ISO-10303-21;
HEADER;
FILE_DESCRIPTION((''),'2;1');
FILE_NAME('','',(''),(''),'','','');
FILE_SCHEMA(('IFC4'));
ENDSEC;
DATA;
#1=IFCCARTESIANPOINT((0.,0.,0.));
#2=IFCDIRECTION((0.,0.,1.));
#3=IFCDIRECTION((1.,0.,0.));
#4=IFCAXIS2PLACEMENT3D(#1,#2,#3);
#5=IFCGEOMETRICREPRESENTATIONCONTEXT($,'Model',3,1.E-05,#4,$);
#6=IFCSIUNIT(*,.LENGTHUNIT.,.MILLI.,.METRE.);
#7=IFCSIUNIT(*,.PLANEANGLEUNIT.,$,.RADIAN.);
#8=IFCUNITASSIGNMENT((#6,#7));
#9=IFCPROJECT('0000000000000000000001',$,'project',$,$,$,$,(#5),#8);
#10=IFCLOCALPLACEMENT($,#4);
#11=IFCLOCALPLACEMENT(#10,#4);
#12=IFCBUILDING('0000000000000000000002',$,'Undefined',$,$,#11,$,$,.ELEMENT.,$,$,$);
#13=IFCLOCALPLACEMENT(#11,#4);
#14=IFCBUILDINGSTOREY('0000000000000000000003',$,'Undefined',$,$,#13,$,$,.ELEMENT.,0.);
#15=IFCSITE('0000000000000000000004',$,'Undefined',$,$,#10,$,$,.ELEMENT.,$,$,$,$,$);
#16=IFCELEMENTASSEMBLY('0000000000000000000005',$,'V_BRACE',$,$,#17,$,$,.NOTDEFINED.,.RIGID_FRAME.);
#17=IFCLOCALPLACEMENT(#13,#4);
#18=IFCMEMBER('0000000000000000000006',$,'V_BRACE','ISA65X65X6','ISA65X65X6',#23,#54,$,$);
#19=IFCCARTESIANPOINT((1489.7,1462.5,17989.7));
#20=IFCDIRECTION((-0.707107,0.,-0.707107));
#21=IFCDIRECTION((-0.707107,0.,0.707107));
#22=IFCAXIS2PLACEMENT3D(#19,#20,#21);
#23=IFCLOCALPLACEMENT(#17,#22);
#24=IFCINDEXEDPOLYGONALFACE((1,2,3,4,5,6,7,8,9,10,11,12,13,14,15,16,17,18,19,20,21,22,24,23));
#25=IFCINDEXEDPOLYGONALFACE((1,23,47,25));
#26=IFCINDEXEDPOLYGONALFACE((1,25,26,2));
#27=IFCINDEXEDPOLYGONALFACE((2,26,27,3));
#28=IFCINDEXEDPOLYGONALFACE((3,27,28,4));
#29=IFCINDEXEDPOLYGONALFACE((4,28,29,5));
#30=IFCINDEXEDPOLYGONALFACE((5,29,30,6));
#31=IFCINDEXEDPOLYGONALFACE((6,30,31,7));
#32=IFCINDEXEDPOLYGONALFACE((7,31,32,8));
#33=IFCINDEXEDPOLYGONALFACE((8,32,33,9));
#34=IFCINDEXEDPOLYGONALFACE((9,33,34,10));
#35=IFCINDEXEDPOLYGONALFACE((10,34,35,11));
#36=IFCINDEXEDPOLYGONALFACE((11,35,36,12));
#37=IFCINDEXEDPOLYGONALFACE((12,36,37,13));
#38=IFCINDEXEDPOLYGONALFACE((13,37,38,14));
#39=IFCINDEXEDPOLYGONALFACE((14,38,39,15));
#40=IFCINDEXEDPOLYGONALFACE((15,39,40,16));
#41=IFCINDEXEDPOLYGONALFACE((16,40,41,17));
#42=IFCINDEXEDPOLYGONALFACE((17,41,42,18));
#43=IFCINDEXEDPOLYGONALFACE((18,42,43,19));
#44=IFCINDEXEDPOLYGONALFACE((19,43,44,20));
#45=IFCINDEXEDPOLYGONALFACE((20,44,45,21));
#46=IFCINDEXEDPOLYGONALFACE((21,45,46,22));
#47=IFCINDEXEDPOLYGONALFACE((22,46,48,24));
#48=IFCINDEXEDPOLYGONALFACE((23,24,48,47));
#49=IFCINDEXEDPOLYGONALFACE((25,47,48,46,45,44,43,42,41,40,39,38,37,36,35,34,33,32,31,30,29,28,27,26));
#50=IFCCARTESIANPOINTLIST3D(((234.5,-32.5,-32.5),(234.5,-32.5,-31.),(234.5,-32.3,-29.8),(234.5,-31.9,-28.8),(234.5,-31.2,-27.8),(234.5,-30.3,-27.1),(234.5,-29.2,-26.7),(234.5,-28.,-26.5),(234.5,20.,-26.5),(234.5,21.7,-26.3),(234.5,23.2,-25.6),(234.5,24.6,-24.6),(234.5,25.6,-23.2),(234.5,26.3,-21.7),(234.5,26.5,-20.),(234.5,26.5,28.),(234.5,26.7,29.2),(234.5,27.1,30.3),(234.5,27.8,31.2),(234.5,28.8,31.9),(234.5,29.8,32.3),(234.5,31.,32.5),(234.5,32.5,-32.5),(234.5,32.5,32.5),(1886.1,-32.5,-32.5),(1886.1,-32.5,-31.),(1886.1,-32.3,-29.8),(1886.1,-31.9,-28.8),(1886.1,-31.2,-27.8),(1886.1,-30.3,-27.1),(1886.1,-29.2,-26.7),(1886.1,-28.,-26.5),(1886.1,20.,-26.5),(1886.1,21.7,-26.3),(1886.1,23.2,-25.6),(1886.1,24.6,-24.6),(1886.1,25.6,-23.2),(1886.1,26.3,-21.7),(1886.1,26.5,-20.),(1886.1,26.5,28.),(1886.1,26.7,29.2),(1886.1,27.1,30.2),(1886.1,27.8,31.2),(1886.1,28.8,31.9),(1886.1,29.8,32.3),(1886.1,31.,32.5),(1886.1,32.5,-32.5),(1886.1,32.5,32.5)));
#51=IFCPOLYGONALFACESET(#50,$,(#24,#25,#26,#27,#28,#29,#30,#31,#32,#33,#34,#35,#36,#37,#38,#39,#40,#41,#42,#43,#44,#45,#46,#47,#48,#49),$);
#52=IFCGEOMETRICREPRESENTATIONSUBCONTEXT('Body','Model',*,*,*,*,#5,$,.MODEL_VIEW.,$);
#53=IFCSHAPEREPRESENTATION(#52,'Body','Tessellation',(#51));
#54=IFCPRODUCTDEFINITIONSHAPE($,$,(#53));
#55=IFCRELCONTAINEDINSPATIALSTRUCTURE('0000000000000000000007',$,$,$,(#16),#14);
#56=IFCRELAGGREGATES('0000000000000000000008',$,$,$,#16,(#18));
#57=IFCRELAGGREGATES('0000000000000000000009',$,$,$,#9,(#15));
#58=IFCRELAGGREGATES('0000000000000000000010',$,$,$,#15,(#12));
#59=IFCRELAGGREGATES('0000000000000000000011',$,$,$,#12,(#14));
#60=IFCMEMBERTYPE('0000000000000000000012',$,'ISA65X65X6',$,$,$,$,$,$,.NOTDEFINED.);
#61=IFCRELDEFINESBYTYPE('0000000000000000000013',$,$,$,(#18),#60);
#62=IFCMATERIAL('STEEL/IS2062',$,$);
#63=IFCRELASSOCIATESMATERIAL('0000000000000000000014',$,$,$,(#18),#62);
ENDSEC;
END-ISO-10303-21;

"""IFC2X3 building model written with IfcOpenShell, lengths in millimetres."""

from ifc_helpers import new_model, si_unit, frame, origin_with_axes, origin_2d_with_axis, place, context, subcontext, project, spatial, l_section, extrude, clip, halfspace, material, type_object, element, aggregate, save


model = new_model("IFC2X3")

# Units and contexts
model_context = context("Model", 3, precision=1e-05, world=origin_with_axes())
body_context = subcontext(model_context, "Body", "Model", "MODEL_VIEW")
ifc_project = project(units=[si_unit("LENGTHUNIT", "METRE", prefix="MILLI"), si_unit("PLANEANGLEUNIT", "RADIAN")], contexts=[model_context])

# Site, building, storey
site_placement = place(None, origin_with_axes())
site = spatial("IfcSite", under=ifc_project, at=site_placement, Name="Undefined", CompositionType="ELEMENT")
building_placement = place(site_placement, origin_with_axes())
building = spatial("IfcBuilding", under=site, at=building_placement, Name="Undefined", CompositionType="ELEMENT")
storey_placement = place(building_placement, origin_with_axes())
storey = spatial("IfcBuildingStorey", under=building, at=storey_placement, Name="Undefined", CompositionType="ELEMENT", Elevation=0.0)

# Shared definitions
ifc_material_1 = material(Name="STEEL/IS2062")

# Element assembly, member
assembly_1_placement = place(storey_placement, origin_with_axes())
assembly_1 = element("IfcElementAssembly", 1, at=assembly_1_placement, inside=storey, Name="V_BRACE", AssemblyPlace="NOTDEFINED", PredefinedType="RIGID_FRAME")
member_type = type_object("IfcMemberType", Name="ISA65X65X6", PredefinedType="NOTDEFINED")
member_placement = place(assembly_1_placement, frame((1489.7, 1462.5, 17989.7), z_axis=(-0.707107, 0.0, -0.707107), x_axis=(-0.707107, 0.0, 0.707107)))
member = element("IfcMember", 2, at=member_placement, type_object=member_type, material=ifc_material_1, Name="V_BRACE", Description="ISA65X65X6", ObjectType="ISA65X65X6", context=body_context, shape_type="Clipping", body=[
    clip(clip(extrude(l_section(Depth=65.0, Width=65.0, Thickness=6.0, FilletRadius=6.5, EdgeRadius=4.5, at=origin_2d_with_axis()), frame((2121.3, 0.0, 0.0), z_axis=(-1.0, 0.0, 0.0), x_axis=(0.0, -1.0, 0.0)), (0.0, 0.0, 1.0), 2121.3), halfspace(frame((1886.1, 32.5, 0.0), z_axis=(-1.0, 0.0, 0.0), x_axis=(0.0, 0.0, -1.0)), True)), halfspace(frame((234.5, 32.5, 0.0), z_axis=(1.0, 0.0, 0.0), x_axis=(0.0, 0.0, 1.0)), True)),
])
aggregate(assembly_1, [member])

save(model, "model.ifc")
